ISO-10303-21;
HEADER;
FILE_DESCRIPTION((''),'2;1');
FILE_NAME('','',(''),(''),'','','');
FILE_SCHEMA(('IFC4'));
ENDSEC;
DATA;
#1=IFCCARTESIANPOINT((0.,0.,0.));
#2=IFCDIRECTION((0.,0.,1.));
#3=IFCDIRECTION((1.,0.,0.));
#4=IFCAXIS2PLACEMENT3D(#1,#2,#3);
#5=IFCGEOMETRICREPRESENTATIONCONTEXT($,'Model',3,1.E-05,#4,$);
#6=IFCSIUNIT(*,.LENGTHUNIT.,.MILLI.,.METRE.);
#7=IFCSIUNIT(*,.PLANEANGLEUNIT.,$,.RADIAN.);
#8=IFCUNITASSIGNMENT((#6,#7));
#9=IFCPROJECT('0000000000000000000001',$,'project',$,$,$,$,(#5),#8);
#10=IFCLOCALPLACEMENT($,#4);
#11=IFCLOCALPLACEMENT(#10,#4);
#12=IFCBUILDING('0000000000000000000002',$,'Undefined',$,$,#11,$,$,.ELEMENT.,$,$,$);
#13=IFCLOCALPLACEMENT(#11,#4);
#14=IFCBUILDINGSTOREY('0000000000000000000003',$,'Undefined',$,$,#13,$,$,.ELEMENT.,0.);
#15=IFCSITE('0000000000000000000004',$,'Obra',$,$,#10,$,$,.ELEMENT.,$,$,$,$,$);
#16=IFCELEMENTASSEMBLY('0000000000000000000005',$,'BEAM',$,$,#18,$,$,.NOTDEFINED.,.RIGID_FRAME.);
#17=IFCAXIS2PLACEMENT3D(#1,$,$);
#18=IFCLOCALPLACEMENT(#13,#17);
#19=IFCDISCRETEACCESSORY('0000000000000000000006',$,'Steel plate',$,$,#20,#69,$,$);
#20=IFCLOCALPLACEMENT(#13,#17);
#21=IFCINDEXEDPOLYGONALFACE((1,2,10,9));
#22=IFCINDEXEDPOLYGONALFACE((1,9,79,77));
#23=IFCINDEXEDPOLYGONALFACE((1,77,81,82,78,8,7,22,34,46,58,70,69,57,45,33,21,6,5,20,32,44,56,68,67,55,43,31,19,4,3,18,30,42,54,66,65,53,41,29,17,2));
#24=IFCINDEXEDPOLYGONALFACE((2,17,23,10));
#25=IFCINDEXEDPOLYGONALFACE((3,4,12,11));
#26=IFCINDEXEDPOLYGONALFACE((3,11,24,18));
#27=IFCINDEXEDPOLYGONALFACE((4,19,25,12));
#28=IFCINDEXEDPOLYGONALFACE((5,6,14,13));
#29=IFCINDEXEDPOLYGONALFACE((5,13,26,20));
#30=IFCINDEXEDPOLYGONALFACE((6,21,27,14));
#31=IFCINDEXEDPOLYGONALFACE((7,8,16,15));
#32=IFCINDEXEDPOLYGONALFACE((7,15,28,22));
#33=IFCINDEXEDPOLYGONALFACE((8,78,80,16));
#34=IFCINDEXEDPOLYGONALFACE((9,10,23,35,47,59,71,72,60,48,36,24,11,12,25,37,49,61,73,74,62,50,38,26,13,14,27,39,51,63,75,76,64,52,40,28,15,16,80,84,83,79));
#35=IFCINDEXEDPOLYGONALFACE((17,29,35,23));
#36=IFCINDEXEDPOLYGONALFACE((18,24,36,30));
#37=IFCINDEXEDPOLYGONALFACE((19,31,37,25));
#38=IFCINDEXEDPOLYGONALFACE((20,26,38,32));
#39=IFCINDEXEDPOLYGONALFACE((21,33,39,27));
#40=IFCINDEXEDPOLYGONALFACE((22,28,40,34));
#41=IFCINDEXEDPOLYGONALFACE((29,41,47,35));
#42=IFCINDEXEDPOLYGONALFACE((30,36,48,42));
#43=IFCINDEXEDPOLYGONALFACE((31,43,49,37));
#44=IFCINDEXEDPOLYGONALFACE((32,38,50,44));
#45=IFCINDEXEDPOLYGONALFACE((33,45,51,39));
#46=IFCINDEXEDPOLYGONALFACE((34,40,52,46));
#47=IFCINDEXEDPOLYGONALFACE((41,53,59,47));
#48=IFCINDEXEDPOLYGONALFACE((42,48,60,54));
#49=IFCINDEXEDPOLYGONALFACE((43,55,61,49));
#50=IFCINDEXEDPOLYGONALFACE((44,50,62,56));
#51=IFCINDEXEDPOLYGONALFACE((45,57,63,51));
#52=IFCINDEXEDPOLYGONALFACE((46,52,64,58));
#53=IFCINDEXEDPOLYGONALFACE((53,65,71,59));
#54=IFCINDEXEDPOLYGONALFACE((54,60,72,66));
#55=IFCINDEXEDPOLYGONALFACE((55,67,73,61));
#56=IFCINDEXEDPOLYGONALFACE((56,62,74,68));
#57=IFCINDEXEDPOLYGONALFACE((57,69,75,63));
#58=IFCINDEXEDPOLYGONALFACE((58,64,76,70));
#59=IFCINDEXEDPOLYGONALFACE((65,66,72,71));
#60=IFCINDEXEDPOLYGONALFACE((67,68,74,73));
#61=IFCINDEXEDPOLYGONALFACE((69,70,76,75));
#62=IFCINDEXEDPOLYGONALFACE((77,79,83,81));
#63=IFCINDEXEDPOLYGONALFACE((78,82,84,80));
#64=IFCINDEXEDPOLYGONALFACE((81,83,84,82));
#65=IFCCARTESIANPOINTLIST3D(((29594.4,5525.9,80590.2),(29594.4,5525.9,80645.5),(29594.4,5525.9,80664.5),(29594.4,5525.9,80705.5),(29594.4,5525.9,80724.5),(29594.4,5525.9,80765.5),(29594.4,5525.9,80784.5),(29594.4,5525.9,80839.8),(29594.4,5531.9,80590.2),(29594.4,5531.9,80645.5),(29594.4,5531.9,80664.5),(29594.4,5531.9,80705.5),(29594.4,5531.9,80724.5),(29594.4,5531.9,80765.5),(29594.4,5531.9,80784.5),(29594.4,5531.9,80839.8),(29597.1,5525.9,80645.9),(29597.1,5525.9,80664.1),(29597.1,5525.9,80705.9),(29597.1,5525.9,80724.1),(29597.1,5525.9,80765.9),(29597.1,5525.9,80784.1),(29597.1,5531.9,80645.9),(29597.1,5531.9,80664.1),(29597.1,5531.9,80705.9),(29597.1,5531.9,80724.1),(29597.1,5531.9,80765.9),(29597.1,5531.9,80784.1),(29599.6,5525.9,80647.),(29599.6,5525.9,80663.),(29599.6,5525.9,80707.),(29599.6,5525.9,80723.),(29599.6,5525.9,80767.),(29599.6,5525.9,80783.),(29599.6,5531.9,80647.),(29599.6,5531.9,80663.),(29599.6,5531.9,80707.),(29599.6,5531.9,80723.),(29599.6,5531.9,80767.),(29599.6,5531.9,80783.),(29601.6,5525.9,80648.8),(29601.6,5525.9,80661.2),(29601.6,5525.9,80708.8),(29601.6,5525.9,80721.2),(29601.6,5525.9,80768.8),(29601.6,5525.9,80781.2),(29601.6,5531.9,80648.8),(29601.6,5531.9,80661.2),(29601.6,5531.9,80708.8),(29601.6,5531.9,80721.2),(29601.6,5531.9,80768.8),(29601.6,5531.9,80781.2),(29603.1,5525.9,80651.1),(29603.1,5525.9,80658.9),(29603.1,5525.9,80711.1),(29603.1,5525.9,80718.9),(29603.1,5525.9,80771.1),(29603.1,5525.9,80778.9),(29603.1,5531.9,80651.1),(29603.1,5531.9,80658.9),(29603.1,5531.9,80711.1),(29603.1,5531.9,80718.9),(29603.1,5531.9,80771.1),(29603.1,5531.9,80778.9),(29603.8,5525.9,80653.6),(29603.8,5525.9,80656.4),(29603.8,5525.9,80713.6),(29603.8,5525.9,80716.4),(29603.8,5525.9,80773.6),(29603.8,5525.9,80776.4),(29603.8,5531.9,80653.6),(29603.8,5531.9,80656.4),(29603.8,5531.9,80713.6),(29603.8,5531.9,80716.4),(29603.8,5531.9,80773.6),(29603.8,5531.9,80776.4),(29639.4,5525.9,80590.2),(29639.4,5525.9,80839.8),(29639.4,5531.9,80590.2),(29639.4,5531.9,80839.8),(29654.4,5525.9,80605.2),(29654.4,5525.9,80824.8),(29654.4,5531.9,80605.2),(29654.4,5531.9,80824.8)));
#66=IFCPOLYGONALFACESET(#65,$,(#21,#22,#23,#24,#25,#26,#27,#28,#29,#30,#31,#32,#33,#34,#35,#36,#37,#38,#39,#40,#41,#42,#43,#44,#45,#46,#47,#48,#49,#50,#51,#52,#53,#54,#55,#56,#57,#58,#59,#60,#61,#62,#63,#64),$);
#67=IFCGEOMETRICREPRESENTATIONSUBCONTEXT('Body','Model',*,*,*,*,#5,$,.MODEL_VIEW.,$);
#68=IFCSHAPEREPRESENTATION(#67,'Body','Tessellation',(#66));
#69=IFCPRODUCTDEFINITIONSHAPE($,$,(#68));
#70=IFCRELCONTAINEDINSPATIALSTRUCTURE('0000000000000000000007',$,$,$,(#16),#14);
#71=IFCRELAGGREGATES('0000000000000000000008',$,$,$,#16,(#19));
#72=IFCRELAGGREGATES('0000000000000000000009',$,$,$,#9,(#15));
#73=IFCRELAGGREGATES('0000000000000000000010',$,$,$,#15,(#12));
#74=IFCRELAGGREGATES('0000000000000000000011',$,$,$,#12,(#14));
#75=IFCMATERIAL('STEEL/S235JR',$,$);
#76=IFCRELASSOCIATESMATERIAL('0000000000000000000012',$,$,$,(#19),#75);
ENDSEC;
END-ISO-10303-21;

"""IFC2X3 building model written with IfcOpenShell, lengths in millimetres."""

from ifc_helpers import new_model, si_unit, frame, origin_with_axes, origin_2d_with_axis, place, context, subcontext, project, spatial, polyline, circle, outline, extrude, source, transform, mapped, material, element, aggregate, save


model = new_model("IFC2X3")

# Units and contexts
model_context = context("Model", 3, precision=1e-05, world=origin_with_axes())
body_context = subcontext(model_context, "Body", "Model", "MODEL_VIEW")
ifc_project = project(units=[si_unit("LENGTHUNIT", "METRE", prefix="MILLI"), si_unit("PLANEANGLEUNIT", "RADIAN")], contexts=[model_context])

# Site, building, storey
site_placement = place(None, origin_with_axes())
site = spatial("IfcSite", under=ifc_project, at=site_placement, Name="Obra", CompositionType="ELEMENT")
building_placement = place(site_placement, origin_with_axes())
building = spatial("IfcBuilding", under=site, at=building_placement, Name="Undefined", CompositionType="ELEMENT")
storey_placement = place(building_placement, origin_with_axes())
storey = spatial("IfcBuildingStorey", under=building, at=storey_placement, Name="Undefined", CompositionType="ELEMENT", Elevation=0.0)

# Shared definitions
ifc_material_1 = material(Name="STEEL/S235JR")

# Element assembly, discrete accessory, opening
assembly_1_placement = place(storey_placement, origin_with_axes())
assembly_1 = element("IfcElementAssembly", 1, at=assembly_1_placement, inside=storey, Name="BEAM", AssemblyPlace="NOTDEFINED", PredefinedType="RIGID_FRAME")
discrete_accessory_1_placement = place(assembly_1_placement, frame((29594.4, 5528.9, 80590.2), z_axis=(0.0, -1.0, 0.0), x_axis=(1.0, 0.0, 0.0)))
discrete_accessory_1 = element("IfcDiscreteAccessory", 2, at=discrete_accessory_1_placement, material=ifc_material_1, Name="Steel plate", context=body_context, shape_type="SweptSolid", body=[
    extrude(outline(polyline([(0.0, 0.0), (45.0, 0.0), (60.0, 15.0), (60.0, 234.6), (45.0, 249.6), (0.0, 249.6), (0.0, 0.0)])), frame((0.0, 0.0, -3.0), z_axis=(0.0, 0.0, 1.0), x_axis=(1.0, 0.0, 0.0)), (0.0, 0.0, 1.0), 6.0),
])
shared_shape_1 = source(origin_with_axes(), body_context, "Body", "SweptSolid", [
    extrude(circle(Radius=9.5, at=origin_2d_with_axis()), frame((0.0, -9.4, 0.0), z_axis=(0.0, 1.0, 0.0), x_axis=(1.0, 0.0, 0.0)), (0.0, 0.0, 1.0), 6.2),
])
opening_1_placement = place(assembly_1_placement, frame((29644.4, 5522.6, 80850.0), z_axis=(-1.0, 0.0, 0.0), x_axis=(0.0, 0.0, -1.0)))
element("IfcOpeningElement", 3, at=opening_1_placement, cuts=discrete_accessory_1, ObjectType="Opening", context=body_context, shape_type="MappedRepresentation", body=[
    mapped(shared_shape_1, transform((75.0, 0.0, 50.0))),
    mapped(shared_shape_1, transform((135.0, 0.0, 50.0))),
    mapped(shared_shape_1, transform((195.0, 0.0, 50.0))),
])
aggregate(assembly_1, [discrete_accessory_1])

save(model, "model.ifc")
